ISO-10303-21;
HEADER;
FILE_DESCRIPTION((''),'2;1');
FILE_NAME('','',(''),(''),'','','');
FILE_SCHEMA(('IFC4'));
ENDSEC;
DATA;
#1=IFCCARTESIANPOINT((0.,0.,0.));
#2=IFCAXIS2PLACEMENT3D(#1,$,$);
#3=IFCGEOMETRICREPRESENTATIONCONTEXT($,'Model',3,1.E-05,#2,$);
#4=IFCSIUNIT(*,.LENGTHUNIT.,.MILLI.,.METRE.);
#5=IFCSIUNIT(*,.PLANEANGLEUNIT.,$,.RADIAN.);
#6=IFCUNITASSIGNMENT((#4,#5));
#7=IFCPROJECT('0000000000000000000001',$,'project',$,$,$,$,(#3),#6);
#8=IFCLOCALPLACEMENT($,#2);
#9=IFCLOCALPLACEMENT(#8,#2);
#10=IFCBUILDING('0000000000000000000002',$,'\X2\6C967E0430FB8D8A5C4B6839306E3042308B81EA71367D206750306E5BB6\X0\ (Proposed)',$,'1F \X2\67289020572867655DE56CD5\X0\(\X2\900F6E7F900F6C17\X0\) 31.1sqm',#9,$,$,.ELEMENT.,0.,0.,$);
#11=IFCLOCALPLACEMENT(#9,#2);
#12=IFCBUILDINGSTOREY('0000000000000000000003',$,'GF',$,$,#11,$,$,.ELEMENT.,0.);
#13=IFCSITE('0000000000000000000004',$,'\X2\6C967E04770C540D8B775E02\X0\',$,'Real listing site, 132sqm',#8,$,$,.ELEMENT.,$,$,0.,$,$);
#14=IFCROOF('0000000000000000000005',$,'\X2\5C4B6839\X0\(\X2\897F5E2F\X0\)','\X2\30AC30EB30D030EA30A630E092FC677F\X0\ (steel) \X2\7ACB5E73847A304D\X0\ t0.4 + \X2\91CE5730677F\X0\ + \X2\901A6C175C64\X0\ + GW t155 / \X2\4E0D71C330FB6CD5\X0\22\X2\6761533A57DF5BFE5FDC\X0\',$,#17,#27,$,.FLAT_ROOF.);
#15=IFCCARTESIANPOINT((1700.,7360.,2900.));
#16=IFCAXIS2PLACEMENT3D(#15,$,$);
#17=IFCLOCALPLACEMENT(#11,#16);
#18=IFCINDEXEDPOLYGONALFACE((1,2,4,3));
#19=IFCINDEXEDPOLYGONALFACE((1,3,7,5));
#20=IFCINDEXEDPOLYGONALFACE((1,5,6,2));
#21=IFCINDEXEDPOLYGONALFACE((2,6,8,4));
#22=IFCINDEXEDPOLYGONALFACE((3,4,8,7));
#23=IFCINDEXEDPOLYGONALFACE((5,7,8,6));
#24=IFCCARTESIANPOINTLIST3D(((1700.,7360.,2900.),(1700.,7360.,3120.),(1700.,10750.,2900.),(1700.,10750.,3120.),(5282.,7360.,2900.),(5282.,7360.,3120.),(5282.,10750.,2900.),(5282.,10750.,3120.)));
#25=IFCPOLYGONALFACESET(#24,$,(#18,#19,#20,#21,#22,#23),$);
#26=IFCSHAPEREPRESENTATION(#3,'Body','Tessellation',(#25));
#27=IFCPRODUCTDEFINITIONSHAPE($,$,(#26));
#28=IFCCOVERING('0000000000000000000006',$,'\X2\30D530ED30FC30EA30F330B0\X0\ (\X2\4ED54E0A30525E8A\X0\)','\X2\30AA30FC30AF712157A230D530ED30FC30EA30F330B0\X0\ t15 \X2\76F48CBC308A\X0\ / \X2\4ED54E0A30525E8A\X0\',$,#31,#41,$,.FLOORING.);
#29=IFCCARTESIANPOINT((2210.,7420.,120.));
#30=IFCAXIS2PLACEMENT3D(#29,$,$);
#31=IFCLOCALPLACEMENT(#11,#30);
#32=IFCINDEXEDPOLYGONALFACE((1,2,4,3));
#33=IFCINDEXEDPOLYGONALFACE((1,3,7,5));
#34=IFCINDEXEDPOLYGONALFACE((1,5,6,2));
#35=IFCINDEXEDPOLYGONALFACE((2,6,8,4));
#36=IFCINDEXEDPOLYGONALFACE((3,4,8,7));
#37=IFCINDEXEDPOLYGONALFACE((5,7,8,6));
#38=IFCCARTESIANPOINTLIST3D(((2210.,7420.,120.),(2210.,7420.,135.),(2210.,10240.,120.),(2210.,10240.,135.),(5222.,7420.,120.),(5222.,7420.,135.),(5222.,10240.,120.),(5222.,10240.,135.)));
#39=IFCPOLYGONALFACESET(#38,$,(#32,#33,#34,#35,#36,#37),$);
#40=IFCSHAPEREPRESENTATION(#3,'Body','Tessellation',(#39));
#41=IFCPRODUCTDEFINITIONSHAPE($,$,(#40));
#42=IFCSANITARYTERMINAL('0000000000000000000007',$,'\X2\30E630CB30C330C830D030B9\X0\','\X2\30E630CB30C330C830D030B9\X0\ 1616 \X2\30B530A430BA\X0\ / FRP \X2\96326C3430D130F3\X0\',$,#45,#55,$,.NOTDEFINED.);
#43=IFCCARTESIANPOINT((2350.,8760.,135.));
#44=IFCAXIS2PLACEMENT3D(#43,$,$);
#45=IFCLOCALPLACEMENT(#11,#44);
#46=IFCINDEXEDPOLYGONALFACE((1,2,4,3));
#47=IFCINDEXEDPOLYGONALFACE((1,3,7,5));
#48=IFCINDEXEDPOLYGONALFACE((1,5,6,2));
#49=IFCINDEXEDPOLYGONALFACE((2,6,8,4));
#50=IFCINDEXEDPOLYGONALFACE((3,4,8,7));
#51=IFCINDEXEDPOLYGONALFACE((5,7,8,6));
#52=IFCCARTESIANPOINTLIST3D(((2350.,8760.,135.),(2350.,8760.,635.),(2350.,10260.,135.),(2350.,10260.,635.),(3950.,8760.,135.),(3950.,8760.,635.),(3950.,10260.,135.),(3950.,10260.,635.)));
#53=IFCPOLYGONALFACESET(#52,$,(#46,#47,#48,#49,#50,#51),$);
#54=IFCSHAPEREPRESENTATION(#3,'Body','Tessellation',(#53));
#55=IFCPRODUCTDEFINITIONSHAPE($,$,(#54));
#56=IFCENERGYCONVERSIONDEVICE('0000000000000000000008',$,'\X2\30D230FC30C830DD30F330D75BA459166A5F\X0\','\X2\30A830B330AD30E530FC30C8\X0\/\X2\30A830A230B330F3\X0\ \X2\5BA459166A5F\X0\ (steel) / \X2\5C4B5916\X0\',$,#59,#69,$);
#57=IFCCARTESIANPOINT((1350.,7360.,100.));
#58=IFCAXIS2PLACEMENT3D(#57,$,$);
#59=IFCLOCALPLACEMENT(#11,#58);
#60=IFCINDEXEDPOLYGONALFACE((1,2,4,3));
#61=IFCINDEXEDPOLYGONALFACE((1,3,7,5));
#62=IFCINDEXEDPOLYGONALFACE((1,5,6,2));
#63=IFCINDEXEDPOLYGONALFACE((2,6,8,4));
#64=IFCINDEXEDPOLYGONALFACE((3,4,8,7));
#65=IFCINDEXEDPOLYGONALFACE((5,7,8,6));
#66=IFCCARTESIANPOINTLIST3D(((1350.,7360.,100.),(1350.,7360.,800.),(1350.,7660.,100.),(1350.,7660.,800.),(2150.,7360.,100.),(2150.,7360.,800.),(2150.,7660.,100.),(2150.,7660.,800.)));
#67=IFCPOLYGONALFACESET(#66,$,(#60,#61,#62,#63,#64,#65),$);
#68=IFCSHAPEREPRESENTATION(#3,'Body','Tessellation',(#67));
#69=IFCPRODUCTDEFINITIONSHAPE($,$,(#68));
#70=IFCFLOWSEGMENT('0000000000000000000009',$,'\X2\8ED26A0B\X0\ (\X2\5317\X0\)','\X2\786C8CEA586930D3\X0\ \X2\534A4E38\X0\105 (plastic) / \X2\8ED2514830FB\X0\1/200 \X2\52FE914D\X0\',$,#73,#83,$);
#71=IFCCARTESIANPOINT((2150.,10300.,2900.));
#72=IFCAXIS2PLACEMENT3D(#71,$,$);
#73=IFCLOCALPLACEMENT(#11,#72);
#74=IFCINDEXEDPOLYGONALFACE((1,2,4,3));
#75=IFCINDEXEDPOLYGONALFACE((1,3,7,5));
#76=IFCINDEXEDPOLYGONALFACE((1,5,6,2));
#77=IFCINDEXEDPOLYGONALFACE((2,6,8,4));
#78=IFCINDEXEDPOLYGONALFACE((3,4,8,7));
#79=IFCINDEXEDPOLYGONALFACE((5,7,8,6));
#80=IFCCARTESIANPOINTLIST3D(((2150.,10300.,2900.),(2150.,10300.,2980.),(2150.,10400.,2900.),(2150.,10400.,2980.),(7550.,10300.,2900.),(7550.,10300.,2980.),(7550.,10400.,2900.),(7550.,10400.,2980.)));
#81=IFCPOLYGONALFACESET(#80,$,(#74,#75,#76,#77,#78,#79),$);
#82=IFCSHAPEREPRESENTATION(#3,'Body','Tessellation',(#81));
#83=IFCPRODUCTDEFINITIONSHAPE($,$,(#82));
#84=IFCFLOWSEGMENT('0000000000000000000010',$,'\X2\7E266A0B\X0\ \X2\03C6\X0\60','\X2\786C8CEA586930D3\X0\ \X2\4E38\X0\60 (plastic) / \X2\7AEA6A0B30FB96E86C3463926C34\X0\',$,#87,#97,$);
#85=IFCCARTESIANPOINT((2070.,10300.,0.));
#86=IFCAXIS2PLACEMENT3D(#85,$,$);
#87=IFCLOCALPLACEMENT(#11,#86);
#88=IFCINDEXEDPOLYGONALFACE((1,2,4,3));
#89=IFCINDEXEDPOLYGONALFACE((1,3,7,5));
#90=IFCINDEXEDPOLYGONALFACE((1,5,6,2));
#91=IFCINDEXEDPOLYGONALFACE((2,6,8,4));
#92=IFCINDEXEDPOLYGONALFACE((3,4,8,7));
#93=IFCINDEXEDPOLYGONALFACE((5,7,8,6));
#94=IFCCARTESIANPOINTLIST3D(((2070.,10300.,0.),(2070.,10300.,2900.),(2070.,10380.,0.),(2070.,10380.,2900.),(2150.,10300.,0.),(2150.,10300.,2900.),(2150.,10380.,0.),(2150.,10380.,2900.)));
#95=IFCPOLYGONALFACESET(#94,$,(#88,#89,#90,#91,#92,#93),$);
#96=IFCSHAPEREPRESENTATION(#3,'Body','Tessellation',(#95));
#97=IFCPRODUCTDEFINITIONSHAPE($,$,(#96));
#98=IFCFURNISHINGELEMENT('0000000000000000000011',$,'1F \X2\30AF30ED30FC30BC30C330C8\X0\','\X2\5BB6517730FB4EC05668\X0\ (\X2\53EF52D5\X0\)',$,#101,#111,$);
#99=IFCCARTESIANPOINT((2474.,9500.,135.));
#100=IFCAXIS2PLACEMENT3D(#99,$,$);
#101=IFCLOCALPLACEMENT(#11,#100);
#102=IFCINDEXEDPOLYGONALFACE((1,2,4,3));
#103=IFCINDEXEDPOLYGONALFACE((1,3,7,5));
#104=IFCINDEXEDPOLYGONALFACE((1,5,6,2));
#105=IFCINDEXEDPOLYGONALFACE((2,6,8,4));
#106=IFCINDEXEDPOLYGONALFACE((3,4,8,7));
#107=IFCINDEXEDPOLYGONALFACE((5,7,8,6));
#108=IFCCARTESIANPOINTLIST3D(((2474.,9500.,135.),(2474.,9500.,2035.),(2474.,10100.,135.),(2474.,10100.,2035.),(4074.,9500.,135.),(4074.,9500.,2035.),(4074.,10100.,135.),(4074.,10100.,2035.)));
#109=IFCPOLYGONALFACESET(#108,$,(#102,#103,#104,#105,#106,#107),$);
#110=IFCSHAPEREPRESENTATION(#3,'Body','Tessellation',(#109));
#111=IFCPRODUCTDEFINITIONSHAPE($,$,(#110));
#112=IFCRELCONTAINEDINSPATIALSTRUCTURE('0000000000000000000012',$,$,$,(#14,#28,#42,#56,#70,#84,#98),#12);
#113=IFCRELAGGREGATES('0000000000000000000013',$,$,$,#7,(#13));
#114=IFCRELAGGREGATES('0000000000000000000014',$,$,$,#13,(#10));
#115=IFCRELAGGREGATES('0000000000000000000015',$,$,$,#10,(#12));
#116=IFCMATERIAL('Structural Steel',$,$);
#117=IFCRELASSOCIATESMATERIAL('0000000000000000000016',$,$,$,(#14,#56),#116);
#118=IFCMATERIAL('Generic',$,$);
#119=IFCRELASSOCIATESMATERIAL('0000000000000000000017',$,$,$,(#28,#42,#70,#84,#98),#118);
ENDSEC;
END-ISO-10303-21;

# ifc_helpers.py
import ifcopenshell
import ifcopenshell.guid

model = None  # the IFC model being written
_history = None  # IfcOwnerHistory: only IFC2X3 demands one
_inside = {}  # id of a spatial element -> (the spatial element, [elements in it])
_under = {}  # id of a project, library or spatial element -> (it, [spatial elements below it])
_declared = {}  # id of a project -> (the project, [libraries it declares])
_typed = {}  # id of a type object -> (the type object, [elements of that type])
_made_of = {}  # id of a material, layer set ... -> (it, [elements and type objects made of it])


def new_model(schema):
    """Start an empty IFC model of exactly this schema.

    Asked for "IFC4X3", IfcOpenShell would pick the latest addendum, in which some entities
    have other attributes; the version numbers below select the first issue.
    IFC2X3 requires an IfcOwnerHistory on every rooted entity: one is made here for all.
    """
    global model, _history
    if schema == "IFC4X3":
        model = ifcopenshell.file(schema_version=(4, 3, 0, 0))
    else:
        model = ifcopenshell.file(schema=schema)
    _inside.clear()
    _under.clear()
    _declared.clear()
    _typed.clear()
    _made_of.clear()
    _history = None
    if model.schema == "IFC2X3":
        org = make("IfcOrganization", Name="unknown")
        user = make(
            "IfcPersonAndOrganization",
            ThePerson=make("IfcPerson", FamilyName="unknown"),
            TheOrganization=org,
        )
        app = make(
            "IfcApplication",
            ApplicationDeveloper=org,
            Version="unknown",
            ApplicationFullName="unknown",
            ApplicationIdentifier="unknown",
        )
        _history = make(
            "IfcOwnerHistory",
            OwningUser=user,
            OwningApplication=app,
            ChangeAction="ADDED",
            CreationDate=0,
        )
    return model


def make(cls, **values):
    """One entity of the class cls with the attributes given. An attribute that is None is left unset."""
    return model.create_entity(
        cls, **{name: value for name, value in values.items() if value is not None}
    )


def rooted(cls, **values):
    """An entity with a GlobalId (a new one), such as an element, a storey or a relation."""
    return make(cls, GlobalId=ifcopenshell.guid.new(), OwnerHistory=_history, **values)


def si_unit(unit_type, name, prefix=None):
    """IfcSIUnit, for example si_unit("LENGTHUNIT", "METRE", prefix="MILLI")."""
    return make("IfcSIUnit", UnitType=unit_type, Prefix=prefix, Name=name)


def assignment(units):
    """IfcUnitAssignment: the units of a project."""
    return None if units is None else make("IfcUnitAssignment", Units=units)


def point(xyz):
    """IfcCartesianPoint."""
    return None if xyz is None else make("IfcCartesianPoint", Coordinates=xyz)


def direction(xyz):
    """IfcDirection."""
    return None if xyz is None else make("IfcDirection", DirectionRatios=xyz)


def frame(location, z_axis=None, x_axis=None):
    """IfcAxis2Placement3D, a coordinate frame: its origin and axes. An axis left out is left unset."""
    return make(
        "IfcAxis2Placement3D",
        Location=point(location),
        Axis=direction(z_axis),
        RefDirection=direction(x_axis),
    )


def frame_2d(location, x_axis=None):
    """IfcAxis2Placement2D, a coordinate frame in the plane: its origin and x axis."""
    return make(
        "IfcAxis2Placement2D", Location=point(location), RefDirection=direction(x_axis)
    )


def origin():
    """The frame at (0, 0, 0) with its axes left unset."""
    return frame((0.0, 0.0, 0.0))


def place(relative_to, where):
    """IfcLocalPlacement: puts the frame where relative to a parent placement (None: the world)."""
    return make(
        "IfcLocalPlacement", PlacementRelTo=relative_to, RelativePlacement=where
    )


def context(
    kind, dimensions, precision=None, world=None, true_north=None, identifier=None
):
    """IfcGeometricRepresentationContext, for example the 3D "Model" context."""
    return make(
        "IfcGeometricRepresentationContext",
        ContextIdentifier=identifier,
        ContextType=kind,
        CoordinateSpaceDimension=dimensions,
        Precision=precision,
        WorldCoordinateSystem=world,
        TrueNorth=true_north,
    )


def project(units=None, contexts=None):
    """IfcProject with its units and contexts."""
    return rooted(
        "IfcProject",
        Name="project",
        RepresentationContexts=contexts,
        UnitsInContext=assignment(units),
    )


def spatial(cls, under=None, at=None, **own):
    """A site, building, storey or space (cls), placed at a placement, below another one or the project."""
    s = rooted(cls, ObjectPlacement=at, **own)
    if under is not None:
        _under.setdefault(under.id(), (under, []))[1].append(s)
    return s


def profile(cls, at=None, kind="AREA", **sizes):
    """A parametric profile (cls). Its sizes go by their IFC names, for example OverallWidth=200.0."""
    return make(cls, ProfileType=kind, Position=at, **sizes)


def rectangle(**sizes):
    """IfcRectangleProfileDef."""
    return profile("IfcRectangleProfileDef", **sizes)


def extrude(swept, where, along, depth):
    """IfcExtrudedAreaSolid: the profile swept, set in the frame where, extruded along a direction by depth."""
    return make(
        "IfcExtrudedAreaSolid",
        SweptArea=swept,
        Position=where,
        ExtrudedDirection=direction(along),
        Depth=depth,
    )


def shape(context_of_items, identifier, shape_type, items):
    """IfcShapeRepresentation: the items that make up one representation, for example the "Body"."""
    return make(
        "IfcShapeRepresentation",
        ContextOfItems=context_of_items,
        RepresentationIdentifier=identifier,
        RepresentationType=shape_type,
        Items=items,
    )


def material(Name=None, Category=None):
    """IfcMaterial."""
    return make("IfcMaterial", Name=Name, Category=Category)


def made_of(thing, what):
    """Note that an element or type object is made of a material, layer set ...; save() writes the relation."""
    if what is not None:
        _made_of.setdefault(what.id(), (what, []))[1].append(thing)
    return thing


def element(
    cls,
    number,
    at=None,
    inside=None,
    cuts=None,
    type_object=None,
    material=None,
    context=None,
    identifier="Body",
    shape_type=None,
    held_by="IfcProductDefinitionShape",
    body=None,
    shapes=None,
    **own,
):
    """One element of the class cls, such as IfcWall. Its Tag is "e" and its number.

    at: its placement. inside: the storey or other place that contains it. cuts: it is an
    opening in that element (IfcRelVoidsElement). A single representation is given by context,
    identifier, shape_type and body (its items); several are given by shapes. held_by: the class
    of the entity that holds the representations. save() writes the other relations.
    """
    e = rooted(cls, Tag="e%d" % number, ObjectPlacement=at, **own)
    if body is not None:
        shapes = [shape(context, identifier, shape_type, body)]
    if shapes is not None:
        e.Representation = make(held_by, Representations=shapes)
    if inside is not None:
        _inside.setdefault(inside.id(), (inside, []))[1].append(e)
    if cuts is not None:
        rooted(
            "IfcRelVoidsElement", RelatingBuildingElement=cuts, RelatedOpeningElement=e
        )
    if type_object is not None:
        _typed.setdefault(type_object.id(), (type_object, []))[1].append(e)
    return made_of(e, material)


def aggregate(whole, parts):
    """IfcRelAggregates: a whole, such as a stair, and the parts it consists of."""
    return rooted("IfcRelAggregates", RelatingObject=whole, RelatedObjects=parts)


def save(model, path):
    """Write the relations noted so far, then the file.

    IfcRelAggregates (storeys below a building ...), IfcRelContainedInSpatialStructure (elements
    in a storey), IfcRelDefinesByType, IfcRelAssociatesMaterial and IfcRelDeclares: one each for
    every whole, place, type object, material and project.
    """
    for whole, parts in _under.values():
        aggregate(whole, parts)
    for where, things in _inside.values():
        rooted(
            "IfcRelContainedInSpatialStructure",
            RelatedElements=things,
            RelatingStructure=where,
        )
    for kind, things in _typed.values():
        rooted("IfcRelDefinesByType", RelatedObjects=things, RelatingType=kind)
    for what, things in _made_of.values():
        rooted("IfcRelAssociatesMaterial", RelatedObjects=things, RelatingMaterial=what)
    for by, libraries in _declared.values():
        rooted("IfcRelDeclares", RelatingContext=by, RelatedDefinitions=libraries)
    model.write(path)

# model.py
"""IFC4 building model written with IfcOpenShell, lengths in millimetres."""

from ifc_helpers import new_model, si_unit, frame, frame_2d, origin, place, context, project, spatial, rectangle, extrude, material, element, save


model = new_model("IFC4")

# Units and contexts
model_context = context("Model", 3, precision=1e-05, world=origin())
ifc_project = project(units=[si_unit("LENGTHUNIT", "METRE", prefix="MILLI"), si_unit("PLANEANGLEUNIT", "RADIAN")], contexts=[model_context])

# Site, building, storey
site_placement = place(None, origin())
site = spatial("IfcSite", under=ifc_project, at=site_placement, Name="沖縄県名護市", ObjectType="Real listing site, 132sqm", CompositionType="ELEMENT", RefElevation=0.0)
building_placement = place(site_placement, origin())
building = spatial("IfcBuilding", under=site, at=building_placement, Name="沖縄・越屋根のある自然素材の家 (Proposed)", ObjectType="1F 木造在来工法(透湿透気) 31.1sqm", CompositionType="ELEMENT", ElevationOfRefHeight=0.0, ElevationOfTerrain=0.0)
storey_placement = place(building_placement, origin())
storey = spatial("IfcBuildingStorey", under=building, at=storey_placement, Name="GF", CompositionType="ELEMENT", Elevation=0.0)

# Roof
ifc_material_1 = material(Name="Structural Steel")
roof_placement = place(storey_placement, frame((1700.0, 7360.0, 2900.0)))
element("IfcRoof", 1, at=roof_placement, inside=storey, material=ifc_material_1, Name="屋根(西帯)", Description="ガルバリウム鋼板 (steel) 立平葺き t0.4 + 野地板 + 通気層 + GW t155 / 不燃・法22条区域対応", PredefinedType="FLAT_ROOF", context=model_context, shape_type="SweptSolid", body=[
    extrude(rectangle(XDim=3582.0, YDim=3390.0, at=frame_2d((1791.0, 1695.0))), frame((1700.0, 7360.0, 2900.0)), (0.0, 0.0, 1.0), 220.0),
])

# Covering
ifc_material_2 = material(Name="Generic")
covering_placement = place(storey_placement, frame((2210.0, 7420.0, 120.0)))
element("IfcCovering", 2, at=covering_placement, inside=storey, material=ifc_material_2, Name="フローリング (仕上げ床)", Description="オーク無垢フローリング t15 直貼り / 仕上げ床", PredefinedType="FLOORING", context=model_context, shape_type="SweptSolid", body=[
    extrude(rectangle(XDim=3012.0, YDim=2820.0, at=frame_2d((1506.0, 1410.0))), frame((2210.0, 7420.0, 120.0)), (0.0, 0.0, 1.0), 15.0),
])

# Sanitary terminal
sanitary_terminal_placement = place(storey_placement, frame((2350.0, 8760.0, 135.0)))
element("IfcSanitaryTerminal", 3, at=sanitary_terminal_placement, inside=storey, material=ifc_material_2, Name="ユニットバス", Description="ユニットバス 1616 サイズ / FRP 防水パン", PredefinedType="NOTDEFINED", context=model_context, shape_type="SweptSolid", body=[
    extrude(rectangle(XDim=1600.0, YDim=1500.0, at=frame_2d((800.0, 750.0))), frame((2350.0, 8760.0, 135.0)), (0.0, 0.0, 1.0), 500.0),
])

# Energy conversion device
energy_conversion_device_placement = place(storey_placement, frame((1350.0, 7360.0, 100.0)))
element("IfcEnergyConversionDevice", 4, at=energy_conversion_device_placement, inside=storey, material=ifc_material_1, Name="ヒートポンプ室外機", Description="エコキュート/エアコン 室外機 (steel) / 屋外", context=model_context, shape_type="SweptSolid", body=[
    extrude(rectangle(XDim=800.0, YDim=300.0, at=frame_2d((400.0, 150.0))), frame((1350.0, 7360.0, 100.0)), (0.0, 0.0, 1.0), 700.0),
])

# Flow segments
flow_segment_1_placement = place(storey_placement, frame((2150.0, 10300.0, 2900.0)))
element("IfcFlowSegment", 5, at=flow_segment_1_placement, inside=storey, material=ifc_material_2, Name="軒樋 (北)", Description="硬質塩ビ 半丸105 (plastic) / 軒先・1/200 勾配", context=model_context, shape_type="SweptSolid", body=[
    extrude(rectangle(XDim=5400.0, YDim=100.0, at=frame_2d((2700.0, 50.0))), frame((2150.0, 10300.0, 2900.0)), (0.0, 0.0, 1.0), 80.0),
])
flow_segment_2_placement = place(storey_placement, frame((2070.0, 10300.0, 0.0)))
element("IfcFlowSegment", 6, at=flow_segment_2_placement, inside=storey, material=ifc_material_2, Name="縦樋 φ60", Description="硬質塩ビ 丸60 (plastic) / 竪樋・雨水排水", context=model_context, shape_type="SweptSolid", body=[
    extrude(rectangle(XDim=80.0, YDim=80.0, at=frame_2d((40.0, 40.0))), frame((2070.0, 10300.0, 0.0)), (0.0, 0.0, 1.0), 2900.0),
])

# Furnishing element
furnishing_placement = place(storey_placement, frame((2474.0, 9500.0, 135.0)))
element("IfcFurnishingElement", 7, at=furnishing_placement, inside=storey, material=ifc_material_2, Name="1F クローゼット", Description="家具・什器 (可動)", context=model_context, shape_type="SweptSolid", body=[
    extrude(rectangle(XDim=1600.0, YDim=600.0, at=frame_2d((800.0, 300.0))), frame((2474.0, 9500.0, 135.0)), (0.0, 0.0, 1.0), 1900.0),
])

save(model, "model.ifc")
